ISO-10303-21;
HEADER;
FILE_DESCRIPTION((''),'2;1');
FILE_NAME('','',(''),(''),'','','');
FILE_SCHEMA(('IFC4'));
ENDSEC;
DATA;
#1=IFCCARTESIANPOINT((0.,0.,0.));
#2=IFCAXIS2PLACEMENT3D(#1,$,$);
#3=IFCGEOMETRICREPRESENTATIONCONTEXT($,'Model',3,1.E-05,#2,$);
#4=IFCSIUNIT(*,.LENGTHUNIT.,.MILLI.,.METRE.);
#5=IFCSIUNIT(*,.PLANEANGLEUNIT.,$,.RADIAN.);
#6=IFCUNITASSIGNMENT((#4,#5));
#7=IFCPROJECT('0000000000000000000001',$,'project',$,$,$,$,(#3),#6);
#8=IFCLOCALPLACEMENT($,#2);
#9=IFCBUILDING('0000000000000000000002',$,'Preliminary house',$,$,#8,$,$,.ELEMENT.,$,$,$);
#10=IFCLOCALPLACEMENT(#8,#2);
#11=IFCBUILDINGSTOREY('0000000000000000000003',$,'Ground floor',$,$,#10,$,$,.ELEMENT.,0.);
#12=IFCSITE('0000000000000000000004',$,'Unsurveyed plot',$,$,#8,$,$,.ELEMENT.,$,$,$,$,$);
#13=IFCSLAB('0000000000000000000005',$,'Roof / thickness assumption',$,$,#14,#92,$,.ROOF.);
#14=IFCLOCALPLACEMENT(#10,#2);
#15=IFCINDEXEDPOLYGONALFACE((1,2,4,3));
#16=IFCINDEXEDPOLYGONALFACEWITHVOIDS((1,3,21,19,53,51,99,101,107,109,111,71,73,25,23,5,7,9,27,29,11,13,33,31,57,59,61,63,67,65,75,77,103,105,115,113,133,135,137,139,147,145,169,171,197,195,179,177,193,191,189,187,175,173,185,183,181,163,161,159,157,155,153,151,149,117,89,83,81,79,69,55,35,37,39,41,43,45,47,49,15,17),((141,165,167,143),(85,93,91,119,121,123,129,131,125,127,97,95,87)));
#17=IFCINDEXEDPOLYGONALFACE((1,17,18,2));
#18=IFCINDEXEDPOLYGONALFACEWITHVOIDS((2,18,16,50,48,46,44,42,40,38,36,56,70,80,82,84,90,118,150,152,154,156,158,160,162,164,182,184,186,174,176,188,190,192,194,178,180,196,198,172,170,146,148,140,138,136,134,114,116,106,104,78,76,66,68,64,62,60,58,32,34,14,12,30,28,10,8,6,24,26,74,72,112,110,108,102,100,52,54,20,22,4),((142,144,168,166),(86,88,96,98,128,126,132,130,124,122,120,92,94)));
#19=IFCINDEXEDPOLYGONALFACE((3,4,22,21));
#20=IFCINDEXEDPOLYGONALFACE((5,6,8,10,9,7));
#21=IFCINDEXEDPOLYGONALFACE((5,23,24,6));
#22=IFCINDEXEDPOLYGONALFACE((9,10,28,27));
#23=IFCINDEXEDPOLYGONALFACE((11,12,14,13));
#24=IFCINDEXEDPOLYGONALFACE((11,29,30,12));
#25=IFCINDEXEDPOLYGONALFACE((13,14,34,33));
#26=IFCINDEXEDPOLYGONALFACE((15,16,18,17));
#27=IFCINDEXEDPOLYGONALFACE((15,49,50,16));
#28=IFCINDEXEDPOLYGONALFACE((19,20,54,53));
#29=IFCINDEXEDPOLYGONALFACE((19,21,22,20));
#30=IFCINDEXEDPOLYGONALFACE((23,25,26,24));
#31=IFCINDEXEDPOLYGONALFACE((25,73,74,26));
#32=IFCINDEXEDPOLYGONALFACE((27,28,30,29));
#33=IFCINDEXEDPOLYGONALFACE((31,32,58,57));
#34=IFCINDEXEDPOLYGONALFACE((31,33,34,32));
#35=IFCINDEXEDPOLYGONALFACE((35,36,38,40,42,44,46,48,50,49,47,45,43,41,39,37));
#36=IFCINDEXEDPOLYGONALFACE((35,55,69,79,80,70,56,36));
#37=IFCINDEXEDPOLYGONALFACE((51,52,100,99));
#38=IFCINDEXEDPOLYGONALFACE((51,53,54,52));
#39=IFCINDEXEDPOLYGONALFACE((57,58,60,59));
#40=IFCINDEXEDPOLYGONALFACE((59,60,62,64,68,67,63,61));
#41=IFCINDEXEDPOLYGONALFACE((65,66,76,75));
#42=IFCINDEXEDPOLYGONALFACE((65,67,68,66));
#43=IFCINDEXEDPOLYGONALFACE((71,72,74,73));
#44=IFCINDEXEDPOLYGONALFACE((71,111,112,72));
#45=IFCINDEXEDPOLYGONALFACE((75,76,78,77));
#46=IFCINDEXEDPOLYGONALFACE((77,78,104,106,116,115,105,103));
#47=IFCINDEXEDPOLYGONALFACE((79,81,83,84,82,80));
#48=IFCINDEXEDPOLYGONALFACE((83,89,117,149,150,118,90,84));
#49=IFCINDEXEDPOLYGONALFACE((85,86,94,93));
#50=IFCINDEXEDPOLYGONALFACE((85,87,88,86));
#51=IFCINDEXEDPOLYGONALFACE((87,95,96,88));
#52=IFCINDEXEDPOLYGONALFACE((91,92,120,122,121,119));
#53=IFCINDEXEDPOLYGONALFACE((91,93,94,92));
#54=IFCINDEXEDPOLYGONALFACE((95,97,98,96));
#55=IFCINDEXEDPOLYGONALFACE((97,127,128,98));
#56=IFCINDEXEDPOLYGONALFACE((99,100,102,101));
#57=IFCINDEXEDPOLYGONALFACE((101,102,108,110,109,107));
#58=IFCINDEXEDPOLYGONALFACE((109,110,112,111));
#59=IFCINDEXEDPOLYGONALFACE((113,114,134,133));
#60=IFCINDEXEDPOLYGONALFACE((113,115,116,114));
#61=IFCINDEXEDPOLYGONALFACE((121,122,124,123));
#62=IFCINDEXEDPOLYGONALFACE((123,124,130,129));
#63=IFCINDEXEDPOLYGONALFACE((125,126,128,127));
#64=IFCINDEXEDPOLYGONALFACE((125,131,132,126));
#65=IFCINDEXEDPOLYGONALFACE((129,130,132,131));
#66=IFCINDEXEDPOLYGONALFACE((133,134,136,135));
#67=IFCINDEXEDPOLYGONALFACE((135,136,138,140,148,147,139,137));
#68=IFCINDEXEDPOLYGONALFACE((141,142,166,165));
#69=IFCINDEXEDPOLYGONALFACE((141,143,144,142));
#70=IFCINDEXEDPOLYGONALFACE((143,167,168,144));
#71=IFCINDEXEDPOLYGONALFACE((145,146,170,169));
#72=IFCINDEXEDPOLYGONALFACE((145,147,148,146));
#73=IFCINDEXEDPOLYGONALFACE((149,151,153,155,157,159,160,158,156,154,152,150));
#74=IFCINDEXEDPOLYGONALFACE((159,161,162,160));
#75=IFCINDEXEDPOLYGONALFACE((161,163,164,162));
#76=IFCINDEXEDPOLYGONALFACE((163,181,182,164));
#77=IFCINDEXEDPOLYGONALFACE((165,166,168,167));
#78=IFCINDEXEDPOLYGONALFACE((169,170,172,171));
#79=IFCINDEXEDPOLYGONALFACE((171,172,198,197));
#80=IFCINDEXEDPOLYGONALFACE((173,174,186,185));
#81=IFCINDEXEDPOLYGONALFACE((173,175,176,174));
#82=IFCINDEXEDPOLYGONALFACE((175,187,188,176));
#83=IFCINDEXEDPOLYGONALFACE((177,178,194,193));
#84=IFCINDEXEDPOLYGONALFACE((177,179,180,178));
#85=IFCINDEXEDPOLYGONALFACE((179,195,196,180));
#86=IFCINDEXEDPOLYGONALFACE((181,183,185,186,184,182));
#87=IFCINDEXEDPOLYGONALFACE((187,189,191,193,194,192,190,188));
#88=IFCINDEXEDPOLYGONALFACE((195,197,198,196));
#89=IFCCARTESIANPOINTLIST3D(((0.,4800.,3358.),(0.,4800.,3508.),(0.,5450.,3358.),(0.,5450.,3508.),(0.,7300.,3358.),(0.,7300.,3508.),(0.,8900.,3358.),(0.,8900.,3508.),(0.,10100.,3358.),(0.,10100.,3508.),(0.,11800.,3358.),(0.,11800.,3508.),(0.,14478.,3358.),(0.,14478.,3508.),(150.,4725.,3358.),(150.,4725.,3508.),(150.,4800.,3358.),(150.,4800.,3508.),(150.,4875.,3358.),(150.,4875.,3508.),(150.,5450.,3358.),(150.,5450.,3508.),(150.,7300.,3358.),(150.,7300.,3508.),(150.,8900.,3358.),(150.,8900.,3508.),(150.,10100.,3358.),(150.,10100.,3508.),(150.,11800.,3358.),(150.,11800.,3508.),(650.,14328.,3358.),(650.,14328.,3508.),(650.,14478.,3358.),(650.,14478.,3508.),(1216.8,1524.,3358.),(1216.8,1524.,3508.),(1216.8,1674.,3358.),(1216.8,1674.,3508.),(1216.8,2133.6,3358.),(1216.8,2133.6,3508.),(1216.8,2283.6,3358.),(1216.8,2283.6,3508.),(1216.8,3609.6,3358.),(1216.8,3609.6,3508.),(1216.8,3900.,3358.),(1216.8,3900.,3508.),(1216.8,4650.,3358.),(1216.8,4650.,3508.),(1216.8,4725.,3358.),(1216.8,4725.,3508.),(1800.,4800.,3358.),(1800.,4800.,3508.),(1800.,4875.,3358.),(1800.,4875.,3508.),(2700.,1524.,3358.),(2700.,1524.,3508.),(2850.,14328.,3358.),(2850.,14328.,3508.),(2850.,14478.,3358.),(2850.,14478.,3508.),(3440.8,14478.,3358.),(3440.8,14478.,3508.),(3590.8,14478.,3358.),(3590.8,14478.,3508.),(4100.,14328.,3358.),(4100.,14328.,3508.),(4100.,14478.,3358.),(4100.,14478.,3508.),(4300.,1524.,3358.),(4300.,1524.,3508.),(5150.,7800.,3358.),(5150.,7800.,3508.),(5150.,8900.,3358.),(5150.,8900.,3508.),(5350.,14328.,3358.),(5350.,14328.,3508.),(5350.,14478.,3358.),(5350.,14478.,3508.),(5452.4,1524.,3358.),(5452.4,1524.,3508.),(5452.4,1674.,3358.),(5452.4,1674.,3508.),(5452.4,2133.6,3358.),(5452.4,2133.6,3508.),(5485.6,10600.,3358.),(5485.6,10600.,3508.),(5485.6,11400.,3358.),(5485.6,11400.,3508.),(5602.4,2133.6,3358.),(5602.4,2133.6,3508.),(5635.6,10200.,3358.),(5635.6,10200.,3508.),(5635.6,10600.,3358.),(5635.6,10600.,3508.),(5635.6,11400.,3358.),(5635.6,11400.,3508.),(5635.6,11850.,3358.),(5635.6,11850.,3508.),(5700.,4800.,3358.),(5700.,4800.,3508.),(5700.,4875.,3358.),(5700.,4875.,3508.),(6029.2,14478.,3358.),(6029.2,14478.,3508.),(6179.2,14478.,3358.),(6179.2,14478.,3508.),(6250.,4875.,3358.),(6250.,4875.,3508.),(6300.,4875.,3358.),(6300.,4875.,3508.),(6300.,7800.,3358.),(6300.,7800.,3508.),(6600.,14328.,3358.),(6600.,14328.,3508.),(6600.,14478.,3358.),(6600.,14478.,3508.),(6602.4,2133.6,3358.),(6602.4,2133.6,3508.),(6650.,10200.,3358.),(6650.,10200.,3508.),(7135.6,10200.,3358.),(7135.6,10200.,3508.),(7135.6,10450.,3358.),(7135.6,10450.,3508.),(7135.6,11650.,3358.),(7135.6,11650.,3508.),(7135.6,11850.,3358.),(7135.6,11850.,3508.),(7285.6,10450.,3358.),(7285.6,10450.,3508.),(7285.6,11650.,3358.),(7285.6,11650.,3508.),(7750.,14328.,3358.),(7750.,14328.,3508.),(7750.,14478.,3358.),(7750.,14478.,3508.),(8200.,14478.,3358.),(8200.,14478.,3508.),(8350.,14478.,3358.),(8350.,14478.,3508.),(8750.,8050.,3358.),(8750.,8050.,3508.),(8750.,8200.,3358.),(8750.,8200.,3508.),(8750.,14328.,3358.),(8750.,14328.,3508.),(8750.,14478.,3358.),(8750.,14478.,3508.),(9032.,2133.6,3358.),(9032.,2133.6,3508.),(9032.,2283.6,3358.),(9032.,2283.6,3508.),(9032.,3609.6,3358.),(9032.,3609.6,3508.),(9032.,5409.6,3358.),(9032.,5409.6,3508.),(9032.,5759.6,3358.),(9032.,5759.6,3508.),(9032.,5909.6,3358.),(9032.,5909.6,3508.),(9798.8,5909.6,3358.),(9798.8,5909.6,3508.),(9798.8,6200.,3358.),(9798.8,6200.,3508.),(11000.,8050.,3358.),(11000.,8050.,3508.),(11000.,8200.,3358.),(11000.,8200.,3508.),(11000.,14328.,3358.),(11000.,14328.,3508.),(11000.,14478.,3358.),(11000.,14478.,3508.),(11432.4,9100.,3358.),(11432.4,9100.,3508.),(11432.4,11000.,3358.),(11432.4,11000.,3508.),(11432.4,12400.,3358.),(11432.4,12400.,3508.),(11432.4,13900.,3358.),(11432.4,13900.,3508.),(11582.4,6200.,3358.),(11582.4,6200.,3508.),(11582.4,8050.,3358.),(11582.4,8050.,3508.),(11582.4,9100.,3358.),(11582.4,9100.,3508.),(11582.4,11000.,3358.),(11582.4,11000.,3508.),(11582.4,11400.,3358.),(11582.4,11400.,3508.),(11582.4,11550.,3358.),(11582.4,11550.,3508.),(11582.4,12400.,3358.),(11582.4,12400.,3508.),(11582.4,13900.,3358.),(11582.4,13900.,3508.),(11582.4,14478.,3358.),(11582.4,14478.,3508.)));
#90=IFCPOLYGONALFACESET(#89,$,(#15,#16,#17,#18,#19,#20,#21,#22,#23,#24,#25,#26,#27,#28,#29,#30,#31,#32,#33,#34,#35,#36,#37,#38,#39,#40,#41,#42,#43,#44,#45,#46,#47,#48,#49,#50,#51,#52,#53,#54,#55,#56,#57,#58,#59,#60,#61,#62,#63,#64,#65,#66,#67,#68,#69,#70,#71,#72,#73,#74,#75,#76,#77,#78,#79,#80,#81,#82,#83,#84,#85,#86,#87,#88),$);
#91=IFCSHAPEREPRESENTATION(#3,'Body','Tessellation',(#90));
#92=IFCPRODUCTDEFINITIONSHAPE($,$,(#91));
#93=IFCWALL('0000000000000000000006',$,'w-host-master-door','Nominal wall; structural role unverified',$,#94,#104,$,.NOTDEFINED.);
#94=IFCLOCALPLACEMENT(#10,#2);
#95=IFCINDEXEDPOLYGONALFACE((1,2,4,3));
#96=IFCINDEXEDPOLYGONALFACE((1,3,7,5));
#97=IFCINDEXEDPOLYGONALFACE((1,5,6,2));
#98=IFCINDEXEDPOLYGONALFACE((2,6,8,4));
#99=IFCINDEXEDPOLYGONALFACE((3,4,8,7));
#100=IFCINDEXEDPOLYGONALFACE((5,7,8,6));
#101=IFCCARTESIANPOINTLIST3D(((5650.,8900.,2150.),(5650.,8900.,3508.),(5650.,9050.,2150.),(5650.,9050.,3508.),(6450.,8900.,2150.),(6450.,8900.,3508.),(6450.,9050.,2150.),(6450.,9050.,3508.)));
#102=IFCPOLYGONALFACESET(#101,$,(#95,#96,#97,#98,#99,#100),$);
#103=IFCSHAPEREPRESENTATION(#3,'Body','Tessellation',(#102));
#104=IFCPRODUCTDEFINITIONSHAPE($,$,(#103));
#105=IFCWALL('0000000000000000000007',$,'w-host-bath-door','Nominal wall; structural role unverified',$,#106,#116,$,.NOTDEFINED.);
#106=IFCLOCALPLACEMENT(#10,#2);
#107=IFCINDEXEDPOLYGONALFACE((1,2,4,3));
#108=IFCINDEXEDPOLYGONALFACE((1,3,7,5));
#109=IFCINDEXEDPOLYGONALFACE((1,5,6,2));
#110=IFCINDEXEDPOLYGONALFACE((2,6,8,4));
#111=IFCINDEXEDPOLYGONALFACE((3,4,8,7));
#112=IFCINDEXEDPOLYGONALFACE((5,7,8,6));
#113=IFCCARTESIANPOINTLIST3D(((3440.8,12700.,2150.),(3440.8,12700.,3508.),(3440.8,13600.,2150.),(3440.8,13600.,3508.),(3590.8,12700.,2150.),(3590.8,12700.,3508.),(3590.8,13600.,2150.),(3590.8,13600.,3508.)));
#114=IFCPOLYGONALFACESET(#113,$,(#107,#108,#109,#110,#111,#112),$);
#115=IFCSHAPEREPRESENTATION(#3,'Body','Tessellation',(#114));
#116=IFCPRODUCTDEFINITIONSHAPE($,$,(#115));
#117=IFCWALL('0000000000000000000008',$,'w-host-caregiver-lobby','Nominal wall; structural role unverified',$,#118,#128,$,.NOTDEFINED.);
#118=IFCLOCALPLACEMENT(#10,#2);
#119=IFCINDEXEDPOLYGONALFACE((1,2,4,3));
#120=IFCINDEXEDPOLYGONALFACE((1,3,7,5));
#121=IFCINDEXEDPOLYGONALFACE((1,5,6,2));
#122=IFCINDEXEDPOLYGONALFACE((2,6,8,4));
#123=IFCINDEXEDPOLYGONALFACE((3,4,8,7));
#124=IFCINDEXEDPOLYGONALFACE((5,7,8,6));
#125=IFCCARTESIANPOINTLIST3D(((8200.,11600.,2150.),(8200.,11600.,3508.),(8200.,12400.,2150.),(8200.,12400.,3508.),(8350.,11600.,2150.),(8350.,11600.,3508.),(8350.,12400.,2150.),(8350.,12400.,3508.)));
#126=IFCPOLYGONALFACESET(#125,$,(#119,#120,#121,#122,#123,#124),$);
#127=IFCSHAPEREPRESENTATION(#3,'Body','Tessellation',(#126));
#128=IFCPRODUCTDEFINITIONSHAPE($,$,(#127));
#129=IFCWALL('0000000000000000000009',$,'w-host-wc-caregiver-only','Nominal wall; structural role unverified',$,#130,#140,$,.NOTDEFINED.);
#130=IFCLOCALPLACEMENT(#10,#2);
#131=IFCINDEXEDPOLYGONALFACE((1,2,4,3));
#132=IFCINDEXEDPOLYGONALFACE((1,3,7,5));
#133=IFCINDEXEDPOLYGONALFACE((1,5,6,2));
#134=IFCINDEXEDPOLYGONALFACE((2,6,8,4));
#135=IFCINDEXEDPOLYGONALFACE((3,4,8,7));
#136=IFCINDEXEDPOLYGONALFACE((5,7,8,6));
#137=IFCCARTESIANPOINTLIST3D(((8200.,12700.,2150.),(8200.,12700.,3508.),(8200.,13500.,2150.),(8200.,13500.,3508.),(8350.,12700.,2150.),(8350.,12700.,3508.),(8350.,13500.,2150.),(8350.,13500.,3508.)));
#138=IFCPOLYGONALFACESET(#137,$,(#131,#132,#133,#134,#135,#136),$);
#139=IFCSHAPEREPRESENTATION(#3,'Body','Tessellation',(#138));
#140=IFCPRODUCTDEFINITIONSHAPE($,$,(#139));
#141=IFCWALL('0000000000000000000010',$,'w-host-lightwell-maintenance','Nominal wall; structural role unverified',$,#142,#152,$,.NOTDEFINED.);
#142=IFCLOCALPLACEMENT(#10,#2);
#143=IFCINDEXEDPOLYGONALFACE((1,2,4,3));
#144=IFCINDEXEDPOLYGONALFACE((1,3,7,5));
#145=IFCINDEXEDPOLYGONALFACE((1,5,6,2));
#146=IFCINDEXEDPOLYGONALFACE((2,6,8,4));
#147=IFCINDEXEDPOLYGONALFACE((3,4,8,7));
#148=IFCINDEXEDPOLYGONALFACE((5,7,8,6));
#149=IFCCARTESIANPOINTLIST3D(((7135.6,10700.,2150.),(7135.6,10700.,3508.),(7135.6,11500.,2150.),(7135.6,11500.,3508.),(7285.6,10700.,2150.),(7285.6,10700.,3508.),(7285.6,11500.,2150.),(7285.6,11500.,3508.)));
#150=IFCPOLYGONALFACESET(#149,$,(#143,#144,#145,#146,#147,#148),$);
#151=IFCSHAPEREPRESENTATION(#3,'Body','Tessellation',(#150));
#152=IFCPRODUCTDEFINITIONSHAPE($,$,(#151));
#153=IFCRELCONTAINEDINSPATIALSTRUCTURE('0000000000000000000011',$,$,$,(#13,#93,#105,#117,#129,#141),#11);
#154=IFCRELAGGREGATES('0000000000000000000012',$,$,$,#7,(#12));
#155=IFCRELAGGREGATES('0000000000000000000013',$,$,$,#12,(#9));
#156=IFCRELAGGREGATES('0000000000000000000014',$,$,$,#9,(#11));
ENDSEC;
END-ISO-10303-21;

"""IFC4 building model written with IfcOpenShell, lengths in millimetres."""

from ifc_helpers import new_model, si_unit, frame, origin, place, context, project, spatial, polyline, outline, extrude, element, save


model = new_model("IFC4")

# Units and contexts
model_context = context("Model", 3, precision=1e-05, world=origin())
ifc_project = project(units=[si_unit("LENGTHUNIT", "METRE", prefix="MILLI"), si_unit("PLANEANGLEUNIT", "RADIAN")], contexts=[model_context])

# Site, building, storey
placement_1 = place(None, origin())
site = spatial("IfcSite", under=ifc_project, at=placement_1, Name="Unsurveyed plot", CompositionType="ELEMENT")
building = spatial("IfcBuilding", under=site, at=placement_1, Name="Preliminary house", CompositionType="ELEMENT")
placement_2 = place(placement_1, origin())
storey = spatial("IfcBuildingStorey", under=building, at=placement_2, Name="Ground floor", CompositionType="ELEMENT", Elevation=0.0)

# Slab
element("IfcSlab", 1, at=placement_2, inside=storey, Name="Roof / thickness assumption", PredefinedType="ROOF", context=model_context, shape_type="SweptSolid", body=[
    extrude(outline(polyline([(9032.0, 3609.6), (9032.0, 2283.6), (9032.0, 2133.6), (6602.4, 2133.6), (5602.4, 2133.6), (5452.4, 2133.6), (5452.4, 1674.0), (5452.4, 1524.0), (4300.0, 1524.0), (2700.0, 1524.0), (1216.8, 1524.0), (1216.8, 1674.0), (1216.8, 2133.6), (1216.8, 2283.6), (1216.8, 3609.6), (1216.8, 3900.0), (1216.8, 4650.0), (1216.8, 4725.0), (150.0, 4725.0), (150.0, 4800.0), (0.0, 4800.0), (0.0, 5450.0), (150.0, 5450.0), (150.0, 4875.0), (1800.0, 4875.0), (1800.0, 4800.0), (5700.0, 4800.0), (5700.0, 4875.0), (6250.0, 4875.0), (6300.0, 4875.0), (6300.0, 7800.0), (5150.0, 7800.0), (5150.0, 8900.0), (150.0, 8900.0), (150.0, 7300.0), (0.0, 7300.0), (0.0, 8900.0), (0.0, 10100.0), (150.0, 10100.0), (150.0, 11800.0), (0.0, 11800.0), (0.0, 14478.0), (650.0, 14478.0), (650.0, 14328.0), (2850.0, 14328.0), (2850.0, 14478.0), (3440.8, 14478.0), (3590.8, 14478.0), (4100.0, 14478.0), (4100.0, 14328.0), (5350.0, 14328.0), (5350.0, 14478.0), (6029.2, 14478.0), (6179.2, 14478.0), (6600.0, 14478.0), (6600.0, 14328.0), (7750.0, 14328.0), (7750.0, 14478.0), (8200.0, 14478.0), (8350.0, 14478.0), (8750.0, 14478.0), (8750.0, 14328.0), (11000.0, 14328.0), (11000.0, 14478.0), (11582.4, 14478.0), (11582.4, 13900.0), (11432.4, 13900.0), (11432.4, 12400.0), (11582.4, 12400.0), (11582.4, 11550.0), (11582.4, 11400.0), (11582.4, 11000.0), (11432.4, 11000.0), (11432.4, 9100.0), (11582.4, 9100.0), (11582.4, 8050.0), (11582.4, 6200.0), (9798.8, 6200.0), (9798.8, 5909.6), (9032.0, 5909.6), (9032.0, 5759.6), (9032.0, 5409.6), (9032.0, 3609.6)]), holes=[polyline([(11000.0, 8050.0), (11000.0, 8200.0), (8750.0, 8200.0), (8750.0, 8050.0), (11000.0, 8050.0)]), polyline([(7135.6, 11650.0), (7135.6, 11850.0), (5635.6, 11850.0), (5635.6, 11400.0), (5485.6, 11400.0), (5485.6, 10600.0), (5635.6, 10600.0), (5635.6, 10200.0), (6650.0, 10200.0), (7135.6, 10200.0), (7135.6, 10450.0), (7285.6, 10450.0), (7285.6, 11650.0), (7135.6, 11650.0)])]), frame((0.0, 0.0, 3358.0)), (0.0, 0.0, 1.0), 150.0),
])

# Walls, openings
wall_1 = element("IfcWall", 2, at=placement_2, inside=storey, Name="w-host-master-door", Description="Nominal wall; structural role unverified", PredefinedType="NOTDEFINED", context=model_context, shape_type="SweptSolid", body=[
    extrude(outline(polyline([(5650.0, 8900.0), (6450.0, 8900.0), (6450.0, 9050.0), (5650.0, 9050.0), (5650.0, 8900.0)])), origin(), (0.0, 0.0, 1.0), 3508.0),
])
element("IfcOpeningElement", 3, at=placement_2, cuts=wall_1, PredefinedType="OPENING", context=model_context, shape_type="SweptSolid", body=[
    extrude(outline(polyline([(5650.0, 8525.0), (6450.0, 8525.0), (6450.0, 9425.0), (5650.0, 9425.0), (5650.0, 8525.0)])), origin(), (0.0, 0.0, 1.0), 2150.0),
])
wall_2 = element("IfcWall", 4, at=placement_2, inside=storey, Name="w-host-bath-door", Description="Nominal wall; structural role unverified", PredefinedType="NOTDEFINED", context=model_context, shape_type="SweptSolid", body=[
    extrude(outline(polyline([(3590.8, 12700.0), (3590.8, 13600.0), (3440.8, 13600.0), (3440.8, 12700.0), (3590.8, 12700.0)])), origin(), (0.0, 0.0, 1.0), 3508.0),
])
element("IfcOpeningElement", 5, at=placement_2, cuts=wall_2, PredefinedType="OPENING", context=model_context, shape_type="SweptSolid", body=[
    extrude(outline(polyline([(3965.8, 12700.0), (3965.8, 13600.0), (3065.8, 13600.0), (3065.8, 12700.0), (3965.8, 12700.0)])), origin(), (0.0, 0.0, 1.0), 2150.0),
])
wall_3 = element("IfcWall", 6, at=placement_2, inside=storey, Name="w-host-caregiver-lobby", Description="Nominal wall; structural role unverified", PredefinedType="NOTDEFINED", context=model_context, shape_type="SweptSolid", body=[
    extrude(outline(polyline([(8350.0, 11600.0), (8350.0, 12400.0), (8200.0, 12400.0), (8200.0, 11600.0), (8350.0, 11600.0)])), origin(), (0.0, 0.0, 1.0), 3508.0),
])
element("IfcOpeningElement", 7, at=placement_2, cuts=wall_3, PredefinedType="OPENING", context=model_context, shape_type="SweptSolid", body=[
    extrude(outline(polyline([(8725.0, 11600.0), (8725.0, 12400.0), (7825.0, 12400.0), (7825.0, 11600.0), (8725.0, 11600.0)])), origin(), (0.0, 0.0, 1.0), 2150.0),
])
wall_4 = element("IfcWall", 8, at=placement_2, inside=storey, Name="w-host-wc-caregiver-only", Description="Nominal wall; structural role unverified", PredefinedType="NOTDEFINED", context=model_context, shape_type="SweptSolid", body=[
    extrude(outline(polyline([(8350.0, 12700.0), (8350.0, 13500.0), (8200.0, 13500.0), (8200.0, 12700.0), (8350.0, 12700.0)])), origin(), (0.0, 0.0, 1.0), 3508.0),
])
element("IfcOpeningElement", 9, at=placement_2, cuts=wall_4, PredefinedType="OPENING", context=model_context, shape_type="SweptSolid", body=[
    extrude(outline(polyline([(8725.0, 12700.0), (8725.0, 13500.0), (7825.0, 13500.0), (7825.0, 12700.0), (8725.0, 12700.0)])), origin(), (0.0, 0.0, 1.0), 2150.0),
])
wall_5 = element("IfcWall", 10, at=placement_2, inside=storey, Name="w-host-lightwell-maintenance", Description="Nominal wall; structural role unverified", PredefinedType="NOTDEFINED", context=model_context, shape_type="SweptSolid", body=[
    extrude(outline(polyline([(7285.6, 10700.0), (7285.6, 11500.0), (7135.6, 11500.0), (7135.6, 10700.0), (7285.6, 10700.0)])), origin(), (0.0, 0.0, 1.0), 3508.0),
])
element("IfcOpeningElement", 11, at=placement_2, cuts=wall_5, PredefinedType="OPENING", context=model_context, shape_type="SweptSolid", body=[
    extrude(outline(polyline([(7660.6, 10700.0), (7660.6, 11500.0), (6760.6, 11500.0), (6760.6, 10700.0), (7660.6, 10700.0)])), origin(), (0.0, 0.0, 1.0), 2150.0),
])

save(model, "model.ifc")
